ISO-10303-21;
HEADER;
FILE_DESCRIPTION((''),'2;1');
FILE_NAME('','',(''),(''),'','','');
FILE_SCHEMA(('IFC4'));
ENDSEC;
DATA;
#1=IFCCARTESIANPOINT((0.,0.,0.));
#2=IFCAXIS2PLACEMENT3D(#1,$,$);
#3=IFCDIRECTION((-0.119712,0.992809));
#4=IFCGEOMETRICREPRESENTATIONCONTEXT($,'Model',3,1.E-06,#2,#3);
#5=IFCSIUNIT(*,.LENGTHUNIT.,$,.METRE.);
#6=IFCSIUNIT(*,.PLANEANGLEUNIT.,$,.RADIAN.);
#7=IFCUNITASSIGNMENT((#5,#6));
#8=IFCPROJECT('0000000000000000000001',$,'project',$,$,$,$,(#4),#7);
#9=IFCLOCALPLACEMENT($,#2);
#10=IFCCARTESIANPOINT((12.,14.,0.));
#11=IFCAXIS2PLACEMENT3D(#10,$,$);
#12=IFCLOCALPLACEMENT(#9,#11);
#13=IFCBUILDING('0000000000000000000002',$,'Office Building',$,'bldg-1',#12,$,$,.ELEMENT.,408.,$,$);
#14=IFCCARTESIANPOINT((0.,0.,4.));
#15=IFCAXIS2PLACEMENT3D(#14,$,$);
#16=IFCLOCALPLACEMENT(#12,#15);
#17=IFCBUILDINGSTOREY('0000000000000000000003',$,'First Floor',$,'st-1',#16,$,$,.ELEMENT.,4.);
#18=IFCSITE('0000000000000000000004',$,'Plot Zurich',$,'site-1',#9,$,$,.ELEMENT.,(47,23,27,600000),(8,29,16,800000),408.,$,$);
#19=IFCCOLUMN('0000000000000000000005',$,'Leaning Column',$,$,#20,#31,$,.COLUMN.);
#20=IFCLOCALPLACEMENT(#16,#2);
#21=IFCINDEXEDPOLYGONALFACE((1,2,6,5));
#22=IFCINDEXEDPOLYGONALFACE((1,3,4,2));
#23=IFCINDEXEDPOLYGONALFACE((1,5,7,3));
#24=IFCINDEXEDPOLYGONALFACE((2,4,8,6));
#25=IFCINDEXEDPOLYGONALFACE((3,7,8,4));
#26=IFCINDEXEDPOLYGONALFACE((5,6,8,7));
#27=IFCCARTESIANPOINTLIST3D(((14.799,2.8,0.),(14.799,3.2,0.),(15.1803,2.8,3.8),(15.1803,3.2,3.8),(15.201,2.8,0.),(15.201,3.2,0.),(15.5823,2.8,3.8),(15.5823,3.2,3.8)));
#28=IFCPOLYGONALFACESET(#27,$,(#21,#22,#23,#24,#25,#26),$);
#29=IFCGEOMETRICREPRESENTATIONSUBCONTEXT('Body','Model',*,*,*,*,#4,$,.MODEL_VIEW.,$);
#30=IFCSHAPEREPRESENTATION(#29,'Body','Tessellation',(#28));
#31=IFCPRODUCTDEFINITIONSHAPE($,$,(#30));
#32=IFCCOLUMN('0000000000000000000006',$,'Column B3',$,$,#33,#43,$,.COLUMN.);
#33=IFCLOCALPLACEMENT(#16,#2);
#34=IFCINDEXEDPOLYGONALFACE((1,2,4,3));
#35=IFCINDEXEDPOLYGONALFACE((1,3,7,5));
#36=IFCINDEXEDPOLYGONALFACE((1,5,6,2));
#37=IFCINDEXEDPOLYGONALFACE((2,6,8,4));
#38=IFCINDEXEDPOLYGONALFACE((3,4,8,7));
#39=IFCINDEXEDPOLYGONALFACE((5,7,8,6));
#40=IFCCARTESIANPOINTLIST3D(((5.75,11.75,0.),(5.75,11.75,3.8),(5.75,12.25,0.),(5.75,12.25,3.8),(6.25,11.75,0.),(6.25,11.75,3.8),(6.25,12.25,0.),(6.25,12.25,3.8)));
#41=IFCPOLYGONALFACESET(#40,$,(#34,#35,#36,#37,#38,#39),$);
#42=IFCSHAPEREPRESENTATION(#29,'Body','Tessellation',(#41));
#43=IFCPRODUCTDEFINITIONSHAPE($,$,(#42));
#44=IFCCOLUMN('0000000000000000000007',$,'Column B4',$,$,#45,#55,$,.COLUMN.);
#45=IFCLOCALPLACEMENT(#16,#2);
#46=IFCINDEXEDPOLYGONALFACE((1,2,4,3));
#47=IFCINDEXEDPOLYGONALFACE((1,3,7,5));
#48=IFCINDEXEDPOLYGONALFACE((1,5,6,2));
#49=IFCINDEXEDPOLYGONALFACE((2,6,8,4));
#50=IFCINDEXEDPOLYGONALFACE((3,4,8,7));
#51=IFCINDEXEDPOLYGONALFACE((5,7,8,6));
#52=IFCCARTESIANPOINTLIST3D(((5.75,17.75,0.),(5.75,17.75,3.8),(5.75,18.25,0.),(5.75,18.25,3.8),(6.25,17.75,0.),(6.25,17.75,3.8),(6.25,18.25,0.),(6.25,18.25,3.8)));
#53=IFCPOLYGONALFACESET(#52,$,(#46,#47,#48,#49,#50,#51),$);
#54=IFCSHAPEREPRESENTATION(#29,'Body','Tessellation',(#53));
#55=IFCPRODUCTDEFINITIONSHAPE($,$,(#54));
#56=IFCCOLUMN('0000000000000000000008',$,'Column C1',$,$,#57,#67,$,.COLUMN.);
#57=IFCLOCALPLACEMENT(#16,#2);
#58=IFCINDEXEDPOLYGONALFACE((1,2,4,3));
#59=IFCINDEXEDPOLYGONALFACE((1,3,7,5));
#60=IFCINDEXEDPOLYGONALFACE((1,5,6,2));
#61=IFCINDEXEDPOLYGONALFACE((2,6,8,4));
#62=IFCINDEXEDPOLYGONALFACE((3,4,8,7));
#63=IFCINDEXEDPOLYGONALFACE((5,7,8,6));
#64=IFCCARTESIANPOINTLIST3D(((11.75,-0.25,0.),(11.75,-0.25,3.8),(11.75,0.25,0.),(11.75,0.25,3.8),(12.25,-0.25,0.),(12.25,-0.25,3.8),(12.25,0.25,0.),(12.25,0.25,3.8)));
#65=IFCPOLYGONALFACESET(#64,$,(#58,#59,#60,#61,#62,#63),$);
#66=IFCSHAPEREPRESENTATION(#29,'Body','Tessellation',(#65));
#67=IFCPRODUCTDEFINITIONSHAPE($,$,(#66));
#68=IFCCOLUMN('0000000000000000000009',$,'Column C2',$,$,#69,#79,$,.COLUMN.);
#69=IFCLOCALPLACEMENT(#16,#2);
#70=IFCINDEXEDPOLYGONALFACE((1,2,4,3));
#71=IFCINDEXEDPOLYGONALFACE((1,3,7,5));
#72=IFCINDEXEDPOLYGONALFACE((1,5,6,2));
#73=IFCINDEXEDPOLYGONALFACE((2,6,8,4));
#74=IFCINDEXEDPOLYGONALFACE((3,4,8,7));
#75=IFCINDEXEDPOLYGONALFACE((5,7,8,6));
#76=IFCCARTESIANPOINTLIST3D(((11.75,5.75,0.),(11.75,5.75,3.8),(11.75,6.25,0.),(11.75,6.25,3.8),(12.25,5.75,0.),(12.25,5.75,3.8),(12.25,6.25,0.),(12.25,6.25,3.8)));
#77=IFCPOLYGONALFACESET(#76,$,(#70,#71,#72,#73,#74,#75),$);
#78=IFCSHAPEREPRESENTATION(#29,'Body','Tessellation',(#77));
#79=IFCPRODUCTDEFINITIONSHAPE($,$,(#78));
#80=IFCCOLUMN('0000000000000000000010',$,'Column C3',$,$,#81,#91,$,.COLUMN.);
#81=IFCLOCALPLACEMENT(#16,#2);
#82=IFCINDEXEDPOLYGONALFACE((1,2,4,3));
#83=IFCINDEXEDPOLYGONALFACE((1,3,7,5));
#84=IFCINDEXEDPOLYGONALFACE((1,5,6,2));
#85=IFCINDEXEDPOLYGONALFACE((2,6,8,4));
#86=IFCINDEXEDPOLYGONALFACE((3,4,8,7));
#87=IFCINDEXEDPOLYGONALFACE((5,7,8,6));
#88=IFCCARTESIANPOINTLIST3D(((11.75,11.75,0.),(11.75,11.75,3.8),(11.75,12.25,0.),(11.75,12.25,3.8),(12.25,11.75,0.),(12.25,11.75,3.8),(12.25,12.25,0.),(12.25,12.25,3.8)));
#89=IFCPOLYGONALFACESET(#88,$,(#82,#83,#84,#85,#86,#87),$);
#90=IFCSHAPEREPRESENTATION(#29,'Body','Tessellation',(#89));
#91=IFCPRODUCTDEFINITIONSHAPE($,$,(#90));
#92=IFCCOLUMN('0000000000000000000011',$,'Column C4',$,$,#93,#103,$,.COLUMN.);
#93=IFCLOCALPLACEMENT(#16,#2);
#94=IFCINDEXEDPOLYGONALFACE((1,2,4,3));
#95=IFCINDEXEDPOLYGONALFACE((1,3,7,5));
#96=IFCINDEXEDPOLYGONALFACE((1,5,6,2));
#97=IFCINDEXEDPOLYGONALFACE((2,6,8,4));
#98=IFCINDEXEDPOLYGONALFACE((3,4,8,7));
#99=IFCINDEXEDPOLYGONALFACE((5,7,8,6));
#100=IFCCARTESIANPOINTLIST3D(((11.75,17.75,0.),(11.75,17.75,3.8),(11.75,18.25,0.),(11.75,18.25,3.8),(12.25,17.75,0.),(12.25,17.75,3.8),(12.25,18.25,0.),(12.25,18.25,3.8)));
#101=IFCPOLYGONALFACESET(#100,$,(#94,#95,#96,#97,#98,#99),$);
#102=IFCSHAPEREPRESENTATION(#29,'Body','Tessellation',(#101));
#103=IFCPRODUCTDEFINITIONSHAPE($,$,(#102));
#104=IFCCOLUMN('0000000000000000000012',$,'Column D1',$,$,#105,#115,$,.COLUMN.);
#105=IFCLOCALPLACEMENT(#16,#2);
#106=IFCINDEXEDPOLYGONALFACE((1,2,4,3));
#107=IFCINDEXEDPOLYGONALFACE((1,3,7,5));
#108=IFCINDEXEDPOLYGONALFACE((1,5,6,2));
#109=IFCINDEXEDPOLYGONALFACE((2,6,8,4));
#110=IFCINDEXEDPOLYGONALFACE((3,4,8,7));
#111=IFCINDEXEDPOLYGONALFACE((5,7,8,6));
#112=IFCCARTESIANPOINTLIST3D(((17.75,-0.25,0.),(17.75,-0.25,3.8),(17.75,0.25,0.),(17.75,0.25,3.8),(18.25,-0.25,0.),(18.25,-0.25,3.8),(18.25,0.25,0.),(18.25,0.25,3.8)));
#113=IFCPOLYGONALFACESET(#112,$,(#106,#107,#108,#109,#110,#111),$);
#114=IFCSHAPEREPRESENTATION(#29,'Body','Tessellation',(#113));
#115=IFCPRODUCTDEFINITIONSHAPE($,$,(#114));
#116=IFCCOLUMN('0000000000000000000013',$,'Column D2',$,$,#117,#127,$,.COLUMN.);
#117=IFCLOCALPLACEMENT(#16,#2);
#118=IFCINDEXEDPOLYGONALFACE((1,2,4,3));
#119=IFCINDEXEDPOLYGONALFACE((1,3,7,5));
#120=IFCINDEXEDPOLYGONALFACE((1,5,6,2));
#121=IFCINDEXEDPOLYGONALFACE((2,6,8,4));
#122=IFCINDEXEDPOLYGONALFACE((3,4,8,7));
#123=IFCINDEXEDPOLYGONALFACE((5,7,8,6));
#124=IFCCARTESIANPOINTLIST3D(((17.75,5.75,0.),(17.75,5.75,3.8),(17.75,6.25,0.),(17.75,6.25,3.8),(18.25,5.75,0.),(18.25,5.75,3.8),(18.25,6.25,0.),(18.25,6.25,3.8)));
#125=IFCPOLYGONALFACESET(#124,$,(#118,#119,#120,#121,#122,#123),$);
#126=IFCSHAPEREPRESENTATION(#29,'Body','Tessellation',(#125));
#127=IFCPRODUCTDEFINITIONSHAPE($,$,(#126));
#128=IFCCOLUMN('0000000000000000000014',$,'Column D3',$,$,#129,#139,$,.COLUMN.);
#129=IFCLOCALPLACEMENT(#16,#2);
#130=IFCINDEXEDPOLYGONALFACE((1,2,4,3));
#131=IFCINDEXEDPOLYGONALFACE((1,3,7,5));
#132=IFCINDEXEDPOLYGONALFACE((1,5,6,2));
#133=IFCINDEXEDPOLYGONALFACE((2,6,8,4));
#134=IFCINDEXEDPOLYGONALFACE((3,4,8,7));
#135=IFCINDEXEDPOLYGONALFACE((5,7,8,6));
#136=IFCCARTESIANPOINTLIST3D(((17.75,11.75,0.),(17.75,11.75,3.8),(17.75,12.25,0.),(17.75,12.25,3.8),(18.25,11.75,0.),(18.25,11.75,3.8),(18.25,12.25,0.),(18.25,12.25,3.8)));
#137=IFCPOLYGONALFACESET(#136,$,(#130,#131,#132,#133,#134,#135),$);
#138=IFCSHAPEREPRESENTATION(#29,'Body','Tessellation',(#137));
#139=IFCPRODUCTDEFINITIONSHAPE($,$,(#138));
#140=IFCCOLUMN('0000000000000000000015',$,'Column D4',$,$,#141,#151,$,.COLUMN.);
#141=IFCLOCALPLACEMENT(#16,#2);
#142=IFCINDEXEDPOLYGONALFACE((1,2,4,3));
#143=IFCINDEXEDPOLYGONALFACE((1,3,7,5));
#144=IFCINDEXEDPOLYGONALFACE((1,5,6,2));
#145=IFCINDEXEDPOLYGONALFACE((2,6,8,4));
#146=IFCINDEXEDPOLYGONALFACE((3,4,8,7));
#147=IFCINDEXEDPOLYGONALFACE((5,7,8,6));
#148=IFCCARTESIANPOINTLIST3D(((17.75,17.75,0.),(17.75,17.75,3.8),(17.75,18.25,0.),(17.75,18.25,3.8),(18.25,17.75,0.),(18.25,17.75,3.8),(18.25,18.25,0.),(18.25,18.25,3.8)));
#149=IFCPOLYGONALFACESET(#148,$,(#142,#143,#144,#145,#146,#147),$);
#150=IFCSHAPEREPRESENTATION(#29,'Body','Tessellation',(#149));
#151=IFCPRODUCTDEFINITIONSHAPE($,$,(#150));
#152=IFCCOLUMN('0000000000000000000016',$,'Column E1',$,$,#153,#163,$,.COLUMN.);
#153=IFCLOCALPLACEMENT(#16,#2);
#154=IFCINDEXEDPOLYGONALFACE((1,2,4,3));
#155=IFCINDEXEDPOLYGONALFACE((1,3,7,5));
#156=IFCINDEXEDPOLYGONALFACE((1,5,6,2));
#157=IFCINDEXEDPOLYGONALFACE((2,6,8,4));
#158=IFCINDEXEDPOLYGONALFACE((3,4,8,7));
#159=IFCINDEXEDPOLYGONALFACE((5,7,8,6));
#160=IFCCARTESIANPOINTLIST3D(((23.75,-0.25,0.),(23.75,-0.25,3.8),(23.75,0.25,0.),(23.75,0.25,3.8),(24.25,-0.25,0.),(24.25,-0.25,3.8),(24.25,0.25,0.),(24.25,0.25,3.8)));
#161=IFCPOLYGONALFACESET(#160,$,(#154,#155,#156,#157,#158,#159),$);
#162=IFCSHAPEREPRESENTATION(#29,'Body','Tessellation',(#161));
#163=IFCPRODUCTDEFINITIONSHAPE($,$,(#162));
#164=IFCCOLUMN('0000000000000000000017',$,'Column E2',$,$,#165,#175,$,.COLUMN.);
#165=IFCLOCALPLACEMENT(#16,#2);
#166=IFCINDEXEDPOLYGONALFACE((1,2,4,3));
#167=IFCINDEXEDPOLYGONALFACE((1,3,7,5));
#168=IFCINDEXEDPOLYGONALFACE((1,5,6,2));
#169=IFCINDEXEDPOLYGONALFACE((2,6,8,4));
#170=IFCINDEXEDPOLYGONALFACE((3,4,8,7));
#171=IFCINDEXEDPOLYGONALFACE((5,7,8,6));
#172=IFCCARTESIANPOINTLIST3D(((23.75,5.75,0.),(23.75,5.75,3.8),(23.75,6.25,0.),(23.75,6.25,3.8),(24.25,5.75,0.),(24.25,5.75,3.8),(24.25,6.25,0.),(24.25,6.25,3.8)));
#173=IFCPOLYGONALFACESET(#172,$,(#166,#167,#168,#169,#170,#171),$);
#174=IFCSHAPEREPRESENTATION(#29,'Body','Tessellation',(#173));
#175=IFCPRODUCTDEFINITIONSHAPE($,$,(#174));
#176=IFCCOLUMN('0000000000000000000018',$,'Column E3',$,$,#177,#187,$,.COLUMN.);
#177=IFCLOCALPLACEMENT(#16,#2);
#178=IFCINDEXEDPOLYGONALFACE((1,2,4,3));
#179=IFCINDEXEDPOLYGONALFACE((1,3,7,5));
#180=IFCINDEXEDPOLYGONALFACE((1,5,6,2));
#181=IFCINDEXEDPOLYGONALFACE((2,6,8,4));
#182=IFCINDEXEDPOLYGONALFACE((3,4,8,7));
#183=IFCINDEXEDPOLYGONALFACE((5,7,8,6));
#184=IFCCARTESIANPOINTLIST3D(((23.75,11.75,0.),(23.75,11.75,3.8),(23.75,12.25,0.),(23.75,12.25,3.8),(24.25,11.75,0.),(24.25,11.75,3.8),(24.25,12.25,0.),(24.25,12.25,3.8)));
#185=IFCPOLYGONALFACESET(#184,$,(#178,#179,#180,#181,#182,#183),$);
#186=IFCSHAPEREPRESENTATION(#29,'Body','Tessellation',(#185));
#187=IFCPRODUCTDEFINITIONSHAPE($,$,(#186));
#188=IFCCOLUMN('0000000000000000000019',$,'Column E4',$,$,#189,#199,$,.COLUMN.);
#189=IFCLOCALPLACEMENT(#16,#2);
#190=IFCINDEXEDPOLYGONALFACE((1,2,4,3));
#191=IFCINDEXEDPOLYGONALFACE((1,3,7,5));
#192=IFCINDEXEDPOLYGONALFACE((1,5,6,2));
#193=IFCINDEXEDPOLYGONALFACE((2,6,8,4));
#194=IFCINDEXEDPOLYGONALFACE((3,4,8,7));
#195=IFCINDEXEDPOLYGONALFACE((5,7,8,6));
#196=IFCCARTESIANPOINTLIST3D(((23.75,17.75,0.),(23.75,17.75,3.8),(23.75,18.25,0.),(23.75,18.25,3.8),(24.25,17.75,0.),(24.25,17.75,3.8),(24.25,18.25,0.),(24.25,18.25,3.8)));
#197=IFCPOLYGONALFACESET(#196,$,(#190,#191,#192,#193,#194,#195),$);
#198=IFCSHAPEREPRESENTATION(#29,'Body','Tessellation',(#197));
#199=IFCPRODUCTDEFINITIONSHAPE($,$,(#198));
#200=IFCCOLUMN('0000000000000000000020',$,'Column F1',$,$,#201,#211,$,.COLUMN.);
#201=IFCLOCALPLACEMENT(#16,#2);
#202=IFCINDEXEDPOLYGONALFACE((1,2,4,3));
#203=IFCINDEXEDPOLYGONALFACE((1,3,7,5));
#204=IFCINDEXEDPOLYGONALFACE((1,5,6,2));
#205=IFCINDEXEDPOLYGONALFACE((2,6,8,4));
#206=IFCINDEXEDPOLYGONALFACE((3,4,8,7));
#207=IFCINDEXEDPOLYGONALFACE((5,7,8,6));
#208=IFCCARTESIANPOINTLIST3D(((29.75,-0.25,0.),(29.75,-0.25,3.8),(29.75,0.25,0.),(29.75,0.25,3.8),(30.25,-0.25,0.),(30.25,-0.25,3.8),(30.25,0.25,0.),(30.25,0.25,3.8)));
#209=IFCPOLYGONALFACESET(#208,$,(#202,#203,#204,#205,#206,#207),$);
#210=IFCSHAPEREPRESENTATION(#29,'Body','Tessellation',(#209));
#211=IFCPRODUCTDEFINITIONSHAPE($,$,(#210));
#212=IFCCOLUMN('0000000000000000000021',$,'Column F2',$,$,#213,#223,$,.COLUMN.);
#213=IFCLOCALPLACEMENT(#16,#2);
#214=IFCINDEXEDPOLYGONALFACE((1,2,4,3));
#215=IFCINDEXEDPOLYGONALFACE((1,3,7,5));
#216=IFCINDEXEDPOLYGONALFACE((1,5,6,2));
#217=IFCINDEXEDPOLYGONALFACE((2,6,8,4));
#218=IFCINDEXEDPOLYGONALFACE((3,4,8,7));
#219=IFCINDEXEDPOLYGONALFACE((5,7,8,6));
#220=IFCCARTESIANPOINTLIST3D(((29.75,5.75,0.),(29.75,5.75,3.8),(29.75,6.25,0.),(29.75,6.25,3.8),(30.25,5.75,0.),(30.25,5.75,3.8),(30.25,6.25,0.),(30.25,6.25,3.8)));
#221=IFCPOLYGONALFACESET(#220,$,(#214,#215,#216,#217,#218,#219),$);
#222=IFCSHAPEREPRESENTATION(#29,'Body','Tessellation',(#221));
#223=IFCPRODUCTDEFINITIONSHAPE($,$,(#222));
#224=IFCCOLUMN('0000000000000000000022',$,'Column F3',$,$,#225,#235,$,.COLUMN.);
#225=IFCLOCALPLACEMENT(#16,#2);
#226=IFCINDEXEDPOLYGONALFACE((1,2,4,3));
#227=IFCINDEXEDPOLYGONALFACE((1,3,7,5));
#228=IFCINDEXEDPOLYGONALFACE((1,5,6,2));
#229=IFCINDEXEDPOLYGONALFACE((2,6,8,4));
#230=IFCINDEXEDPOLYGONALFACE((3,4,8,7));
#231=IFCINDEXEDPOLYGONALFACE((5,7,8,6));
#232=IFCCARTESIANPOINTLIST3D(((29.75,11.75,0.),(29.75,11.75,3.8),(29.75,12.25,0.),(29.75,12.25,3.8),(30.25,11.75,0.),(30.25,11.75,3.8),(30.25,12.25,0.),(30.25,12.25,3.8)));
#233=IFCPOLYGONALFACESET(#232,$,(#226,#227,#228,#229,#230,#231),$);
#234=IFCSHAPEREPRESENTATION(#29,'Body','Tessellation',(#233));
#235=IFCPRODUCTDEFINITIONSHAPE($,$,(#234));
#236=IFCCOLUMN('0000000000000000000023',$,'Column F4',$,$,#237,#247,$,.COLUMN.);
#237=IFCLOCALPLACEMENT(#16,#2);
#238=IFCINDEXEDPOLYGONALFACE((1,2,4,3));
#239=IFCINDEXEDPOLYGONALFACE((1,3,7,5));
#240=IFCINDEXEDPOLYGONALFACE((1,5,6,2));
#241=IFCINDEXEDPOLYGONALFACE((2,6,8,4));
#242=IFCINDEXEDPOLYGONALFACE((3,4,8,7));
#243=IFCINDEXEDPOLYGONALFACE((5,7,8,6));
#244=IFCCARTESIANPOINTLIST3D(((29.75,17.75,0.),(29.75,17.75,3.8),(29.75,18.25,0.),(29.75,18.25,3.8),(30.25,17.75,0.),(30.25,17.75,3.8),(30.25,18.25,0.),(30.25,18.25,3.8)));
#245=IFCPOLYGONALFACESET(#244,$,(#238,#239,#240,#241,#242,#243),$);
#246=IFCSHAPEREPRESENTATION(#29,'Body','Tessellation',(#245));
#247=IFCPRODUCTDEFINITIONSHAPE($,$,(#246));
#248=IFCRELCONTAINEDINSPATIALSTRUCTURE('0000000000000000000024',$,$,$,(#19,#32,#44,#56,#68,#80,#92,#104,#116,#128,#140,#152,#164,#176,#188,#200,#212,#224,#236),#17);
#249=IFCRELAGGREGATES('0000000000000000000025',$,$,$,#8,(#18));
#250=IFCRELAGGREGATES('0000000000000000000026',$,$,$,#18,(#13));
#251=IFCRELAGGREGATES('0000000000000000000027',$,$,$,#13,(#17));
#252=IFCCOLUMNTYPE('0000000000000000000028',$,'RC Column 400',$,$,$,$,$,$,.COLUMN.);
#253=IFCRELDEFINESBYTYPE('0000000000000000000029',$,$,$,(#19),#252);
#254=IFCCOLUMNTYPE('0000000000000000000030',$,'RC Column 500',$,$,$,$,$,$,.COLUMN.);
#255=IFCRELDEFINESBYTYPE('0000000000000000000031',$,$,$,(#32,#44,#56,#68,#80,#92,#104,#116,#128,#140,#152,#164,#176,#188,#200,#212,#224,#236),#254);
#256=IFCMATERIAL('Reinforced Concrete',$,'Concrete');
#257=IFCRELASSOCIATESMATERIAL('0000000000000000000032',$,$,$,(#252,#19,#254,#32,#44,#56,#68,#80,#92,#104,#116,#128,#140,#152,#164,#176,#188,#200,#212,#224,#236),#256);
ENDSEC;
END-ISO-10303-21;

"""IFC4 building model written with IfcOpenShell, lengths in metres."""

from ifc_helpers import new_model, si_unit, direction, frame, origin, origin_2d, place, context, subcontext, project, spatial, polyline, rectangle, outline, extrude, material, type_object, element, save


model = new_model("IFC4")

# Units and contexts
model_context = context("Model", 3, precision=1e-06, world=origin(), true_north=direction((-0.119712, 0.992809)))
body_context = subcontext(model_context, "Body", "Model", "MODEL_VIEW")
ifc_project = project(units=[si_unit("LENGTHUNIT", "METRE"), si_unit("PLANEANGLEUNIT", "RADIAN")], contexts=[model_context])

# Site, building, storey
site_placement = place(None, origin())
site = spatial("IfcSite", under=ifc_project, at=site_placement, Name="Plot Zurich", ObjectType="site-1", CompositionType="ELEMENT", RefLatitude=(47, 23, 27, 600000), RefLongitude=(8, 29, 16, 800000), RefElevation=408.0)
building_placement = place(site_placement, frame((12.0, 14.0, 0.0)))
building = spatial("IfcBuilding", under=site, at=building_placement, Name="Office Building", ObjectType="bldg-1", CompositionType="ELEMENT", ElevationOfRefHeight=408.0)
storey_placement = place(building_placement, frame((0.0, 0.0, 4.0)))
storey = spatial("IfcBuildingStorey", under=building, at=storey_placement, Name="First Floor", ObjectType="st-1", CompositionType="ELEMENT", Elevation=4.0)

# Columns
ifc_material_1 = material(Name="Reinforced Concrete", Category="Concrete")
column_type_1 = type_object("IfcColumnType", Name="RC Column 400", PredefinedType="COLUMN", material=ifc_material_1)
column_placement = place(storey_placement, frame((15.0, 3.0, 0.0)))
element("IfcColumn", 1, at=column_placement, inside=storey, type_object=column_type_1, material=ifc_material_1, Name="Leaning Column", PredefinedType="COLUMN", context=body_context, shape_type="SweptSolid", body=[
    extrude(outline(polyline([(-0.201, -0.2), (0.201, -0.2), (0.201, 0.2), (-0.201, 0.2), (-0.201, -0.2)])), origin(), (0.099833, 0.0, 0.995004), 3.8191),
])
column_type_2 = type_object("IfcColumnType", Name="RC Column 500", PredefinedType="COLUMN", material=ifc_material_1)
for number, where, name in (
    (2, (6.0, 12.0, 0.0), "Column B3"),
    (3, (6.0, 18.0, 0.0), "Column B4"),
    (4, (12.0, 0.0, 0.0), "Column C1"),
    (5, (12.0, 6.0, 0.0), "Column C2"),
    (6, (12.0, 12.0, 0.0), "Column C3"),
    (7, (12.0, 18.0, 0.0), "Column C4"),
    (8, (18.0, 0.0, 0.0), "Column D1"),
    (9, (18.0, 6.0, 0.0), "Column D2"),
    (10, (18.0, 12.0, 0.0), "Column D3"),
    (11, (18.0, 18.0, 0.0), "Column D4"),
    (12, (24.0, 0.0, 0.0), "Column E1"),
    (13, (24.0, 6.0, 0.0), "Column E2"),
    (14, (24.0, 12.0, 0.0), "Column E3"),
    (15, (24.0, 18.0, 0.0), "Column E4"),
    (16, (30.0, 0.0, 0.0), "Column F1"),
    (17, (30.0, 6.0, 0.0), "Column F2"),
    (18, (30.0, 12.0, 0.0), "Column F3"),
    (19, (30.0, 18.0, 0.0), "Column F4"),
):
    element("IfcColumn", number, at=place(storey_placement, frame(where)), inside=storey, type_object=column_type_2, material=ifc_material_1, Name=name, PredefinedType="COLUMN", context=body_context, shape_type="SweptSolid", body=[
        extrude(rectangle(XDim=0.5, YDim=0.5, at=origin_2d()), origin(), (0.0, 0.0, 1.0), 3.8),
    ])

save(model, "model.ifc")
